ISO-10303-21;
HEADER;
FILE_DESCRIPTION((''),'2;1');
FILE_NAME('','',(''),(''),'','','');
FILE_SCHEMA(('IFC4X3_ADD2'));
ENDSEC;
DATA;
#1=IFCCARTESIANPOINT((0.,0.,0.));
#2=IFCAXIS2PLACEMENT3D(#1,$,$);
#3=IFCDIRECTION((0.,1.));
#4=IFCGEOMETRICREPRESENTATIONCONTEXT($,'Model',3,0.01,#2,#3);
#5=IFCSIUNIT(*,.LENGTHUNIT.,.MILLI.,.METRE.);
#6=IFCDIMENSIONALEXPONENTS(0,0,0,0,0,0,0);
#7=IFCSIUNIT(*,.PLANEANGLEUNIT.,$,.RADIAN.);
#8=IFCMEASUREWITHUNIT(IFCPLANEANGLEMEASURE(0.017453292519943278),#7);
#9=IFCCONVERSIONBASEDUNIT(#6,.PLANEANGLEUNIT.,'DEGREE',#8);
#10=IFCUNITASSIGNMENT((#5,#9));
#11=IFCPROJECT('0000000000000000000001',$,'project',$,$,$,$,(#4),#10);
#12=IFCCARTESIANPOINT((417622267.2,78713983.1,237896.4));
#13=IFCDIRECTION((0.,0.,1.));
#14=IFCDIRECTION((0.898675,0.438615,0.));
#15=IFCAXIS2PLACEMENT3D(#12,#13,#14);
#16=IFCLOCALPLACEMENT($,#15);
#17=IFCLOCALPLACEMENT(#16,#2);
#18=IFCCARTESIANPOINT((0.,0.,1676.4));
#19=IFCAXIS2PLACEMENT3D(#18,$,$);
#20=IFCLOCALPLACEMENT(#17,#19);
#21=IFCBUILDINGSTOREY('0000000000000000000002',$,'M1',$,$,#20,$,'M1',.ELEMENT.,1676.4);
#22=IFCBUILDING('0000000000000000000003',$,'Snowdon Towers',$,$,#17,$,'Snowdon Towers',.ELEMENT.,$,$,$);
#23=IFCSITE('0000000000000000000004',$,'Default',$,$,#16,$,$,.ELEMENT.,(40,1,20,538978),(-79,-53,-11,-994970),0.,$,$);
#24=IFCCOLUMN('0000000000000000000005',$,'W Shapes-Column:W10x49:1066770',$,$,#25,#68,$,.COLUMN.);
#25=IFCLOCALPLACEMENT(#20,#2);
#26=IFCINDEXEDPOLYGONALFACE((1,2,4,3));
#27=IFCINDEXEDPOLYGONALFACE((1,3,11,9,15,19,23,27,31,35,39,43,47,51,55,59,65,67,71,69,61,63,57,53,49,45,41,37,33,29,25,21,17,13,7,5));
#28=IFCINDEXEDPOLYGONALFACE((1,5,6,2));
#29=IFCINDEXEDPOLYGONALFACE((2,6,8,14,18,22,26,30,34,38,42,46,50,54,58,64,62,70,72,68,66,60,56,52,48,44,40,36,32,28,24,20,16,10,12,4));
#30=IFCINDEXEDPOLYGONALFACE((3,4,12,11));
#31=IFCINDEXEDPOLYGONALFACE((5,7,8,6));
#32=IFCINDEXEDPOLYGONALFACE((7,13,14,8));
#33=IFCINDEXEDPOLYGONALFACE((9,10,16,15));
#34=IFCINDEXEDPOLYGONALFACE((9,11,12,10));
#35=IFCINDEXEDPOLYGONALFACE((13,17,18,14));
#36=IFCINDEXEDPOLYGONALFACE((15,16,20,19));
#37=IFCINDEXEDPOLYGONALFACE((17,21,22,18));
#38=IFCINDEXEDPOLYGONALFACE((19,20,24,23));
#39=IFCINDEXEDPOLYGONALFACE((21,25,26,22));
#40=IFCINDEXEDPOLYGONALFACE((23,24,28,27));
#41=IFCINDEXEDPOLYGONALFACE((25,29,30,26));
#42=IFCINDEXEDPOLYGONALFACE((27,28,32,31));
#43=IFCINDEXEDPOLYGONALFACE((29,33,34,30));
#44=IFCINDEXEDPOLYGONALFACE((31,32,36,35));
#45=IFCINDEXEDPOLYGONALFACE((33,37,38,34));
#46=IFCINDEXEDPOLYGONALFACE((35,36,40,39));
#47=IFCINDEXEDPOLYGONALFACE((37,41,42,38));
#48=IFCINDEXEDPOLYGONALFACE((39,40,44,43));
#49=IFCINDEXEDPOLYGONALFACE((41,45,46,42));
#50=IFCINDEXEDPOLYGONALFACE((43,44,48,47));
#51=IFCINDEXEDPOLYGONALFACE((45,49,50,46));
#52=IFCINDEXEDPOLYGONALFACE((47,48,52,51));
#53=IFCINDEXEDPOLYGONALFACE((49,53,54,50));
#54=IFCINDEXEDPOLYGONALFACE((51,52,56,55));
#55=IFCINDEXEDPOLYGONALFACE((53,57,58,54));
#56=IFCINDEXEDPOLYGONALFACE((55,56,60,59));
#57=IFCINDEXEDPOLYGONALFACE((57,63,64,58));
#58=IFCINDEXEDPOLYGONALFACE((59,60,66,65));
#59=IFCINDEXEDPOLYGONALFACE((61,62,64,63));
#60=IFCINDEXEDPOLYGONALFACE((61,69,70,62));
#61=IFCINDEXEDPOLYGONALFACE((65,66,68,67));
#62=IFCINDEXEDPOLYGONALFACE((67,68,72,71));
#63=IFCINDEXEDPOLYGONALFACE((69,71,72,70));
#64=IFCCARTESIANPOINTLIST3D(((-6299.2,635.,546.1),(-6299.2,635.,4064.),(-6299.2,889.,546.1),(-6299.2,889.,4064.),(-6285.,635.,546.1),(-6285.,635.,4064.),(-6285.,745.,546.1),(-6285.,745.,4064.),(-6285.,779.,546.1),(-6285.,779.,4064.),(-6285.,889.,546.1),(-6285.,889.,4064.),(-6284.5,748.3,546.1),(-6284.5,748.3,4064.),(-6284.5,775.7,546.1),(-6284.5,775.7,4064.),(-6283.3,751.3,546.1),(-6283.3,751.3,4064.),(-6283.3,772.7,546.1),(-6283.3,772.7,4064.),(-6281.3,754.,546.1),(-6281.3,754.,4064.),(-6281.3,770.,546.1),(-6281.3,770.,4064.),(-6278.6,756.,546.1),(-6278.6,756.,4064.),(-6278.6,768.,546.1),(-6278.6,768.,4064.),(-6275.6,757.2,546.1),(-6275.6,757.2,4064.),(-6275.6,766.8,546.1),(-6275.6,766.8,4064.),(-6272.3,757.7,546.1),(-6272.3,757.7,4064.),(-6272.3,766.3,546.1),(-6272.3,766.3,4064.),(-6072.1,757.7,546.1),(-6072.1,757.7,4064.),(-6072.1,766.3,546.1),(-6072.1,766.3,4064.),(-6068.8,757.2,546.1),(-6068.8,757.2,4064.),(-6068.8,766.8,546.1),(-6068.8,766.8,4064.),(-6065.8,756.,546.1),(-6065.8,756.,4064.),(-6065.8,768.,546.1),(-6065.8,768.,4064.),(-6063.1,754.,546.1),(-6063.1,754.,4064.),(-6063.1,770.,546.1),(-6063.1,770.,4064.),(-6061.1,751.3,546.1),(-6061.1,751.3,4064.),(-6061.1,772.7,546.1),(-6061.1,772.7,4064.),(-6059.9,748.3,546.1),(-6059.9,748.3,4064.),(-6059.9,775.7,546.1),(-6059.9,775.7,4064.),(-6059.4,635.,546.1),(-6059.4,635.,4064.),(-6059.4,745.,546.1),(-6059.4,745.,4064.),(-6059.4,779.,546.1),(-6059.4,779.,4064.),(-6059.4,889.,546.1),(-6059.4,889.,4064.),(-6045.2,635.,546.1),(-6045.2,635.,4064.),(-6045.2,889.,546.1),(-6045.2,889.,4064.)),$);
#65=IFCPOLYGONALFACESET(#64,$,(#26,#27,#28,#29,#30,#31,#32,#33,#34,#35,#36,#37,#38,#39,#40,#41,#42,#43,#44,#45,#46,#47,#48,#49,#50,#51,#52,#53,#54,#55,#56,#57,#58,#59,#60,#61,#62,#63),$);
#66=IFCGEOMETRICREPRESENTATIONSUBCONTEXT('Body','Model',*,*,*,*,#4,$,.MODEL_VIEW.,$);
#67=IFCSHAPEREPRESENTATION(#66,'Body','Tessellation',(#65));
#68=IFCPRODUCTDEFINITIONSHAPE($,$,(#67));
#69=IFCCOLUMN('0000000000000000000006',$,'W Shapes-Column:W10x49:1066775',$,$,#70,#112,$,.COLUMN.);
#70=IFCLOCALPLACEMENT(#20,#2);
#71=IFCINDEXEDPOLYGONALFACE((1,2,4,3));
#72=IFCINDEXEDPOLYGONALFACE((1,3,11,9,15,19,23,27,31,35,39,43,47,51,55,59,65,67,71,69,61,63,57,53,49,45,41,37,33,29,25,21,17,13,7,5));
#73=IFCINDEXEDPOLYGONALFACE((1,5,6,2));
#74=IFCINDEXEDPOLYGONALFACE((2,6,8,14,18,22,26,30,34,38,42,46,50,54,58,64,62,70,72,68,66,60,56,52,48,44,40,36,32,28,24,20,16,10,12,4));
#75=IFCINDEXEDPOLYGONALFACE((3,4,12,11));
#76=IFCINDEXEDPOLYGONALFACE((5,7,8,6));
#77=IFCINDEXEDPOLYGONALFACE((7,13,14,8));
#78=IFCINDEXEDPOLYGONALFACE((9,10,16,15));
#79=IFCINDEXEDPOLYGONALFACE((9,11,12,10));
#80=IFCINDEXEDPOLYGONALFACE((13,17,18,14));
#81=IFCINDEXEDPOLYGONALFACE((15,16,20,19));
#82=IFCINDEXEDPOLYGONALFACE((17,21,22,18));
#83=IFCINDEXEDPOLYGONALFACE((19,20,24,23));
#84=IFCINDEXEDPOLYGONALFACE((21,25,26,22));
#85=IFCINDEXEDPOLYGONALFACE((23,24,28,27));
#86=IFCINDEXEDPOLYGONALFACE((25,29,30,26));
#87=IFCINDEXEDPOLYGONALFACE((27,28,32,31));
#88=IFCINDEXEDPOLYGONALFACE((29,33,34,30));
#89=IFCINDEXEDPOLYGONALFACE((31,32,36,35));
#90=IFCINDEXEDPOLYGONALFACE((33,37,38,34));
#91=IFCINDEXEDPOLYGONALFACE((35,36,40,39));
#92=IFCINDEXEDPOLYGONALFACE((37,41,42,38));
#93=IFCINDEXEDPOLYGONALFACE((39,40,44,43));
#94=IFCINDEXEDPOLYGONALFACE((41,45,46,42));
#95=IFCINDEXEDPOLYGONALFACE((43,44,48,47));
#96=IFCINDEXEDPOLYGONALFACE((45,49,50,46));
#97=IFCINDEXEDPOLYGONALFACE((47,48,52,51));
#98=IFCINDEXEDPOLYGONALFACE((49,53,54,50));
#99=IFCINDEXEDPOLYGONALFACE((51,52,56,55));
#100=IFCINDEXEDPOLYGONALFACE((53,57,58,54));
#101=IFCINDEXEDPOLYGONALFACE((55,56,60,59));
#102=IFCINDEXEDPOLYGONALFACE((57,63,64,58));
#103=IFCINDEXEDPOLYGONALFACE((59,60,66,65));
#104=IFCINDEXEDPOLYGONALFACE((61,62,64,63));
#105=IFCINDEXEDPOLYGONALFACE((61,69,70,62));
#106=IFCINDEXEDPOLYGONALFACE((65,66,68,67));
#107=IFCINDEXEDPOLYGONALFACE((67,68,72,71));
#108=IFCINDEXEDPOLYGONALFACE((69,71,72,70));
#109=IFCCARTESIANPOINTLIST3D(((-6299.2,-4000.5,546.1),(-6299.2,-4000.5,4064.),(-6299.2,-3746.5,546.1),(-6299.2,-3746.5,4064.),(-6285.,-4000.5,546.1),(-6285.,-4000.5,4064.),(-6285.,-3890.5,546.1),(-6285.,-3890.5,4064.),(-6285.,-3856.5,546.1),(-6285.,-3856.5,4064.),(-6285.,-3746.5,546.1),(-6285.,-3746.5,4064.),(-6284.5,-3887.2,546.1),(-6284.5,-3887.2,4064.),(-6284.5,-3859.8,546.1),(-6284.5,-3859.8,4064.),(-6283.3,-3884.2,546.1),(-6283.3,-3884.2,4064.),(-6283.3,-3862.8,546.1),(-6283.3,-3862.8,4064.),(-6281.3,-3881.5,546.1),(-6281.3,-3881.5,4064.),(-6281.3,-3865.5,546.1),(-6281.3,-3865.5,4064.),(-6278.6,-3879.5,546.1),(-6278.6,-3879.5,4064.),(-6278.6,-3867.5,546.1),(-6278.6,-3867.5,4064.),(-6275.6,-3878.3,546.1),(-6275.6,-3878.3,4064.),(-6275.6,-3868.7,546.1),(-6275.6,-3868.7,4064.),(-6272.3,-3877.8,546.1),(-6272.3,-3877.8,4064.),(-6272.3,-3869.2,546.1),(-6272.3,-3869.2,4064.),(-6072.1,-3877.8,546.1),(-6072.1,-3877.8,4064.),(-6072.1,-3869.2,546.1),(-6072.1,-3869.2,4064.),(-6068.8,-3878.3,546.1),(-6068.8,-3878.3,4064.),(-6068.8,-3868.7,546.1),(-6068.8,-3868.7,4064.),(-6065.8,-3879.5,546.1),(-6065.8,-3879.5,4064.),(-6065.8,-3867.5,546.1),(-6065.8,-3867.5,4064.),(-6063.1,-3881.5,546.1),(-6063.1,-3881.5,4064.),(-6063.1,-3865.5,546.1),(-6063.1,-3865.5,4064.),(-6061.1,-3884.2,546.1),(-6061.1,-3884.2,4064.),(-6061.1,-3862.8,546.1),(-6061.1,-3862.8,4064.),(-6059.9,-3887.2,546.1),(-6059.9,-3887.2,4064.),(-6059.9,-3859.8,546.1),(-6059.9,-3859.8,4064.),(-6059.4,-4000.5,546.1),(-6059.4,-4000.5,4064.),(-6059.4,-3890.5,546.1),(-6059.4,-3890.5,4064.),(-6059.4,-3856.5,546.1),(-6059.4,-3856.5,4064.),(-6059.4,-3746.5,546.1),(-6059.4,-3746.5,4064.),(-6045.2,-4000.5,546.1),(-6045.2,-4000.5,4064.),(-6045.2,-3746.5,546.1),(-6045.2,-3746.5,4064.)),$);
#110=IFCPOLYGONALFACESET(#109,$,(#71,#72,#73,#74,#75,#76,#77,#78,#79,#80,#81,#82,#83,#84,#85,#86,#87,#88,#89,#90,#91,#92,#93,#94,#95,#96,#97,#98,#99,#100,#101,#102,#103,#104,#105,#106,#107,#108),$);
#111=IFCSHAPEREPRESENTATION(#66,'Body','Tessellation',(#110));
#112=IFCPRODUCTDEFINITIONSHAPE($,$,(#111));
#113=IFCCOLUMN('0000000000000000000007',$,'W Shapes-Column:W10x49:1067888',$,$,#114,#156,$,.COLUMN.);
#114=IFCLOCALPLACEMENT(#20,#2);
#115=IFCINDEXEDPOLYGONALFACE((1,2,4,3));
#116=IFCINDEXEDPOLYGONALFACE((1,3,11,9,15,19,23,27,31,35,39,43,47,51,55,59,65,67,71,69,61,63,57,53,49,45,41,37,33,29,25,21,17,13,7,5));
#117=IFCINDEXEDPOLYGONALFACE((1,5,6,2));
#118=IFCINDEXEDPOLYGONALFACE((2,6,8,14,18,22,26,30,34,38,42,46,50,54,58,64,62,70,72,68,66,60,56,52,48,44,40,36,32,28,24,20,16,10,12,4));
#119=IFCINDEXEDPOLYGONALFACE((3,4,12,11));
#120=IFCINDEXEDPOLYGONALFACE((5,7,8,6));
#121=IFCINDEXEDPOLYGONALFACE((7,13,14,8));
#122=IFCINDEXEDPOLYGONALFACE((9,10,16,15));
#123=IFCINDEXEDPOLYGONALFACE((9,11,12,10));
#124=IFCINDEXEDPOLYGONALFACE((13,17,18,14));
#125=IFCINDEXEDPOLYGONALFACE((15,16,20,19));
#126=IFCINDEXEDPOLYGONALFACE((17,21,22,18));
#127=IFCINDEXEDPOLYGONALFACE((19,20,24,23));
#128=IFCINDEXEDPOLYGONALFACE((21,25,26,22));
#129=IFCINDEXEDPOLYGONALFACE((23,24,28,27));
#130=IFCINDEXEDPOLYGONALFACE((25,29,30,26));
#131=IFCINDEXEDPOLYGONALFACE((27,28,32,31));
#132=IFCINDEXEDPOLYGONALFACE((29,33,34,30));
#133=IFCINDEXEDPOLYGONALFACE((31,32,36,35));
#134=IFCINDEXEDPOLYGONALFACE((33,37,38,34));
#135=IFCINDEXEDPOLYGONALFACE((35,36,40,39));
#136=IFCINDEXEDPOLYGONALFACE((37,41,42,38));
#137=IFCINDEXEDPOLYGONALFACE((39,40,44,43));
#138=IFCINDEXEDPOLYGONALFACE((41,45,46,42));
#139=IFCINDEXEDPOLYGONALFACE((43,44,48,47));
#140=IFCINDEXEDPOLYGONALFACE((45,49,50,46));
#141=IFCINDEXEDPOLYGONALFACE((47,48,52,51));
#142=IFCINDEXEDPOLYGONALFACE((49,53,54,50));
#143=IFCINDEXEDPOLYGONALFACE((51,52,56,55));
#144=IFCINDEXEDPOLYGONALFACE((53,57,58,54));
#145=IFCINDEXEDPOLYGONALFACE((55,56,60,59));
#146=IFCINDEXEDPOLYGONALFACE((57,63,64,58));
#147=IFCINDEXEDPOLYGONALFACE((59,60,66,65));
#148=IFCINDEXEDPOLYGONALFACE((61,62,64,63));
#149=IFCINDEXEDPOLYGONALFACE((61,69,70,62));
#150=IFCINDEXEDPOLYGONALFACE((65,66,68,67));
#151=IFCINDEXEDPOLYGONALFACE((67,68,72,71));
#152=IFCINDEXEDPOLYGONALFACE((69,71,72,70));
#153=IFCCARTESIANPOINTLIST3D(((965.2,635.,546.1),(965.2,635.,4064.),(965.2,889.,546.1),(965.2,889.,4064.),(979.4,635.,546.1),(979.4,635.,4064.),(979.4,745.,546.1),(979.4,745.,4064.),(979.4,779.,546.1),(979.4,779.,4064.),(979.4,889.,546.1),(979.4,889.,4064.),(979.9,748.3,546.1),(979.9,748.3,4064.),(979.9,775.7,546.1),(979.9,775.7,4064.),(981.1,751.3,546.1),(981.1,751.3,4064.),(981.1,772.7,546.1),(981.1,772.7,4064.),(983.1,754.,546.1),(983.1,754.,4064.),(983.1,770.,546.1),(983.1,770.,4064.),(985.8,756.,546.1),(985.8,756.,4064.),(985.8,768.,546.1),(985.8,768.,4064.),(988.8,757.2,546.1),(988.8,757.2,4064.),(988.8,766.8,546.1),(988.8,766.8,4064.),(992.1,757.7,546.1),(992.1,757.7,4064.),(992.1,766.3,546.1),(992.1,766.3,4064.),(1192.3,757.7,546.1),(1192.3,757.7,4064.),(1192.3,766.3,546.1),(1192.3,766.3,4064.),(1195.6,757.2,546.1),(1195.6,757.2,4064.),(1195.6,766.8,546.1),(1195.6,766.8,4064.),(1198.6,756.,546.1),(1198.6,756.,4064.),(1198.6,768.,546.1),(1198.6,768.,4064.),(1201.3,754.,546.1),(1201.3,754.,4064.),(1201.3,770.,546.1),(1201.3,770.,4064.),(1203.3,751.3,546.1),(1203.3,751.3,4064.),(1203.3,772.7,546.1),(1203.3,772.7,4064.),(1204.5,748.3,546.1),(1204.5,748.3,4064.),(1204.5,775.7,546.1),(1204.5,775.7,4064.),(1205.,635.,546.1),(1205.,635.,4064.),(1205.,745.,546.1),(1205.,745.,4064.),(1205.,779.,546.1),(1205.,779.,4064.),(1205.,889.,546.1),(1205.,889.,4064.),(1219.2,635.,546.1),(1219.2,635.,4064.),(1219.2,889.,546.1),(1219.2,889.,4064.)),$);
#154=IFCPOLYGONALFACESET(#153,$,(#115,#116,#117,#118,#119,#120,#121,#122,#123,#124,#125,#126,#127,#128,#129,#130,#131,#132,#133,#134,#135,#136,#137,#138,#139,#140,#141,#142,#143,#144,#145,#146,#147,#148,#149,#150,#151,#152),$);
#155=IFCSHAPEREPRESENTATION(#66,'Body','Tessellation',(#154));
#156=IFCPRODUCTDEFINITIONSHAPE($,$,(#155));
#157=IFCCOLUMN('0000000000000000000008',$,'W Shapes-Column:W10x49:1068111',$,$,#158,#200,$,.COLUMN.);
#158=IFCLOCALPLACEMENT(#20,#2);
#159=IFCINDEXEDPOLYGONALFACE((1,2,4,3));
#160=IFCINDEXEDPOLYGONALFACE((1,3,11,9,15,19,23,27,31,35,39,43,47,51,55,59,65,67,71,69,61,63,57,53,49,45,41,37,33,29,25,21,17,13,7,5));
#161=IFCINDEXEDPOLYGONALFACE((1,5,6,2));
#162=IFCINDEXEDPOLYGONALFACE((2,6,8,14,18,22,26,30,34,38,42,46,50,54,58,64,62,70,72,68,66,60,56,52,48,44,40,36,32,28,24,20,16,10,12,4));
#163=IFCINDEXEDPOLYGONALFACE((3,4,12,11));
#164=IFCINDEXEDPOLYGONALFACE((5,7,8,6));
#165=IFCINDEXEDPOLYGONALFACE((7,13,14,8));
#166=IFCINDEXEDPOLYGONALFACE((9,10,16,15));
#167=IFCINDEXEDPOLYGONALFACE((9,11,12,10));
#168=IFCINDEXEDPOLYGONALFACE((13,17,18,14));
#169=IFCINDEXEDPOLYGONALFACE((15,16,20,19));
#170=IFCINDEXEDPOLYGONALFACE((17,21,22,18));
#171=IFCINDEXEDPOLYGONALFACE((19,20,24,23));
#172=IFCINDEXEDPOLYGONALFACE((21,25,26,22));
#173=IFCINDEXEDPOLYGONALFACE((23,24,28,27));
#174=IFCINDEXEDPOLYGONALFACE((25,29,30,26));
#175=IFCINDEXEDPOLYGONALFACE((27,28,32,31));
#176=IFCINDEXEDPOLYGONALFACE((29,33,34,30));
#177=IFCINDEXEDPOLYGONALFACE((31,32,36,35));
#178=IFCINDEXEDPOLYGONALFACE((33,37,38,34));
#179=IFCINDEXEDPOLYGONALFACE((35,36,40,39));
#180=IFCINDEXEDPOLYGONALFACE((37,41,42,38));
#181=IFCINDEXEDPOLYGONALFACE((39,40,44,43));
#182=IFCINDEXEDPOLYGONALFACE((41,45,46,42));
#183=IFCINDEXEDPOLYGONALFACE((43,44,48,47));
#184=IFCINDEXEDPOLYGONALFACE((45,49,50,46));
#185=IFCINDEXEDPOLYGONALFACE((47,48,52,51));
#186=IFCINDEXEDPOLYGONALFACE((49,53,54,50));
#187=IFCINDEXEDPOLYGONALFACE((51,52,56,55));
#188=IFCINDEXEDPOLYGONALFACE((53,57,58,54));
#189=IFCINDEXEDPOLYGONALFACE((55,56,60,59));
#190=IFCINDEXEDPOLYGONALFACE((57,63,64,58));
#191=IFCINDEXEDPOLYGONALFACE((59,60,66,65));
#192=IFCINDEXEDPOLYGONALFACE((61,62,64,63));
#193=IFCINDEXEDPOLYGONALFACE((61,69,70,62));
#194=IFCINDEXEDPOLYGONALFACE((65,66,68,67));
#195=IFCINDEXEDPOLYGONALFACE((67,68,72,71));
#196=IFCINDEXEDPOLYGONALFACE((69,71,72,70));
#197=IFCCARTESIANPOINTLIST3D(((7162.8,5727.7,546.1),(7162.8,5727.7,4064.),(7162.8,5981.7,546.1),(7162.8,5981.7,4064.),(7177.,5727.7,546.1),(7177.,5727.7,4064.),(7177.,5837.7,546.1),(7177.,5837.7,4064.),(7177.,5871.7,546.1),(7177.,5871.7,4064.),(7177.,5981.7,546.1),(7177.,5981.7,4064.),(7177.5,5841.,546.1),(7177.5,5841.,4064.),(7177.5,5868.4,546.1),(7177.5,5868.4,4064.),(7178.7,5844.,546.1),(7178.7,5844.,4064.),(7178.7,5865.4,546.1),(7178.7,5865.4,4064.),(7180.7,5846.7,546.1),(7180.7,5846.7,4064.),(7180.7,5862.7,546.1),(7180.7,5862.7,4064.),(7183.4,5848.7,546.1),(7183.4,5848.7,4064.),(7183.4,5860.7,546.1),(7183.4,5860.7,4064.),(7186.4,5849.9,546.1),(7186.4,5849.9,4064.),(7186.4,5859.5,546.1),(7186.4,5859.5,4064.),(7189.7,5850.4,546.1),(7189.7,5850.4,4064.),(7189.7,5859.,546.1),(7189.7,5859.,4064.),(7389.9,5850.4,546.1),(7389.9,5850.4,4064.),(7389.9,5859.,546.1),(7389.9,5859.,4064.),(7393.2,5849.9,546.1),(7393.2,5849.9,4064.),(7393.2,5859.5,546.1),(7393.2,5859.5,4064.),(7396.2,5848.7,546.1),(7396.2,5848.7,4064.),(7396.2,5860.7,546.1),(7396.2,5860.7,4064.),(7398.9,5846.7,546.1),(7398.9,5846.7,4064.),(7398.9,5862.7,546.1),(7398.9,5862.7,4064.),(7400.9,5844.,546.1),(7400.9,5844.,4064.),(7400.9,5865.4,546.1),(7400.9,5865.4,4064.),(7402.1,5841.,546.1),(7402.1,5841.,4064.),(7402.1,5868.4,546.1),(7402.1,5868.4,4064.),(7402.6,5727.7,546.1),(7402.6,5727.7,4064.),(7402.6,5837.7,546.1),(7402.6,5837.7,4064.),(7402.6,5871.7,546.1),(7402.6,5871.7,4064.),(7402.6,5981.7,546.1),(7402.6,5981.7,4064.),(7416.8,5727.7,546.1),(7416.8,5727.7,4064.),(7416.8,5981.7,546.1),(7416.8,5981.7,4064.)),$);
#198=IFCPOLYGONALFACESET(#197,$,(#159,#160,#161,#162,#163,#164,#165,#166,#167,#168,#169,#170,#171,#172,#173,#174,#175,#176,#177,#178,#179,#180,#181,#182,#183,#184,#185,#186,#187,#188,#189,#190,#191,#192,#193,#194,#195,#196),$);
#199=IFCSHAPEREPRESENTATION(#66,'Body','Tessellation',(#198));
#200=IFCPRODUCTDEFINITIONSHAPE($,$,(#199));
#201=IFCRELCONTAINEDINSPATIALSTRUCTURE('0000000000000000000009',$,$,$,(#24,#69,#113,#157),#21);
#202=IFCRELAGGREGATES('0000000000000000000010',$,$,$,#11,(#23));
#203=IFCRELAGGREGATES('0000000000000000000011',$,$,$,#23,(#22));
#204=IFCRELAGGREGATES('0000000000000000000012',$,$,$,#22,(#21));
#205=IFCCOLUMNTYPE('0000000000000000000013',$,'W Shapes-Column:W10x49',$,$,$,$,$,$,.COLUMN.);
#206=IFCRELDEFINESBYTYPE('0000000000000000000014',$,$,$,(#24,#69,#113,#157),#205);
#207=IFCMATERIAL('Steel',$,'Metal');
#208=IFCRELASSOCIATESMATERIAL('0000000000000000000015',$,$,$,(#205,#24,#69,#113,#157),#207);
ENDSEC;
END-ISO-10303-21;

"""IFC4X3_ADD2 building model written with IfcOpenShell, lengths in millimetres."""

from ifc_helpers import new_model, entity, si_unit, converted_unit, direction, frame, frame_2d, origin, place, context, subcontext, project, spatial, i_section, extrude, source, transform, mapped, material, material_profile, profile_set, profile_usage, type_object, type_shapes, element, save


model = new_model("IFC4X3_ADD2")

# Units and contexts
model_context = context("Model", 3, precision=0.01, world=origin(), true_north=direction((0.0, 1.0)))
body_context = subcontext(model_context, "Body", "Model", "MODEL_VIEW")
ifc_project = project(units=[si_unit("LENGTHUNIT", "METRE", prefix="MILLI"), converted_unit("PLANEANGLEUNIT", "DEGREE", entity("IfcPlaneAngleMeasure", 0.017453292519943278), si_unit("PLANEANGLEUNIT", "RADIAN"), dimensions=[0, 0, 0, 0, 0, 0, 0])], contexts=[model_context])

# Site, building, storey
site_placement = place(None, frame((417622267.2, 78713983.1, 237896.4), z_axis=(0.0, 0.0, 1.0), x_axis=(0.898675, 0.438615, 0.0)))
site = spatial("IfcSite", under=ifc_project, at=site_placement, Name="Default", CompositionType="ELEMENT", RefLatitude=(40, 1, 20, 538978), RefLongitude=(-79, -53, -11, -994970), RefElevation=0.0)
building_placement = place(site_placement, origin())
building = spatial("IfcBuilding", under=site, at=building_placement, Name="Snowdon Towers", LongName="Snowdon Towers", CompositionType="ELEMENT")
storey_placement = place(building_placement, frame((0.0, 0.0, 1676.4)))
storey = spatial("IfcBuildingStorey", under=building, at=storey_placement, Name="M1", LongName="M1", CompositionType="ELEMENT", Elevation=1676.4)

# Columns
ifc_material_1 = material(Name="Steel", Category="Metal")
ifc_material_profile_1 = material_profile(ifc_material_1, i_section(OverallWidth=254.0, OverallDepth=254.0, WebThickness=8.6, FlangeThickness=14.2, FilletRadius=12.7, at=frame_2d((0.0, 0.0), x_axis=(1.0, 0.0))), Name="W10x49")
ifc_profile_set_1 = profile_set([ifc_material_profile_1], Name="W10x49")
ifc_profile_usage_1 = profile_usage(ifc_profile_set_1)
column_type_1 = type_object("IfcColumnType", Name="W Shapes-Column:W10x49", PredefinedType="COLUMN", material=ifc_profile_set_1)
shared_shape_1 = source(origin(), body_context, "Body", "SweptSolid", [
    extrude(i_section(OverallWidth=254.0, OverallDepth=254.0, WebThickness=8.6, FlangeThickness=14.2, FilletRadius=12.7, at=frame_2d((0.0, 0.0), x_axis=(1.0, 0.0))), frame((0.0, 0.0, 2222.5), z_axis=(0.0, 0.0, 1.0), x_axis=(-1.0, 0.0, 0.0)), (0.0, 0.0, 1.0), 3517.9),
])
type_shapes(column_type_1, [shared_shape_1])
for number, where, z_axis, x_axis, name in (
    (1, (-6172.2, 762.0, -1676.4), (0.0, 0.0, 1.0), (0.0, 1.0, 0.0), "W Shapes-Column:W10x49:1066770"),
    (2, (-6172.2, -3873.5, -1676.4), (0.0, 0.0, 1.0), (0.0, 1.0, 0.0), "W Shapes-Column:W10x49:1066775"),
    (3, (1092.2, 762.0, -1676.4), (0.0, 0.0, 1.0), (0.0, 1.0, 0.0), "W Shapes-Column:W10x49:1067888"),
    (4, (7289.8, 5854.7, -1676.4), (0.0, 0.0, 1.0), (0.0, 1.0, 0.0), "W Shapes-Column:W10x49:1068111"),
):
    element("IfcColumn", number, at=place(storey_placement, frame(where, z_axis=z_axis, x_axis=x_axis)), inside=storey, type_object=column_type_1, material=ifc_profile_usage_1, Name=name, PredefinedType="COLUMN", context=body_context, shape_type="MappedRepresentation", body=[
        mapped(shared_shape_1, transform((0.0, 0.0, 0.0), scale=1.0)),
    ])

save(model, "model.ifc")
